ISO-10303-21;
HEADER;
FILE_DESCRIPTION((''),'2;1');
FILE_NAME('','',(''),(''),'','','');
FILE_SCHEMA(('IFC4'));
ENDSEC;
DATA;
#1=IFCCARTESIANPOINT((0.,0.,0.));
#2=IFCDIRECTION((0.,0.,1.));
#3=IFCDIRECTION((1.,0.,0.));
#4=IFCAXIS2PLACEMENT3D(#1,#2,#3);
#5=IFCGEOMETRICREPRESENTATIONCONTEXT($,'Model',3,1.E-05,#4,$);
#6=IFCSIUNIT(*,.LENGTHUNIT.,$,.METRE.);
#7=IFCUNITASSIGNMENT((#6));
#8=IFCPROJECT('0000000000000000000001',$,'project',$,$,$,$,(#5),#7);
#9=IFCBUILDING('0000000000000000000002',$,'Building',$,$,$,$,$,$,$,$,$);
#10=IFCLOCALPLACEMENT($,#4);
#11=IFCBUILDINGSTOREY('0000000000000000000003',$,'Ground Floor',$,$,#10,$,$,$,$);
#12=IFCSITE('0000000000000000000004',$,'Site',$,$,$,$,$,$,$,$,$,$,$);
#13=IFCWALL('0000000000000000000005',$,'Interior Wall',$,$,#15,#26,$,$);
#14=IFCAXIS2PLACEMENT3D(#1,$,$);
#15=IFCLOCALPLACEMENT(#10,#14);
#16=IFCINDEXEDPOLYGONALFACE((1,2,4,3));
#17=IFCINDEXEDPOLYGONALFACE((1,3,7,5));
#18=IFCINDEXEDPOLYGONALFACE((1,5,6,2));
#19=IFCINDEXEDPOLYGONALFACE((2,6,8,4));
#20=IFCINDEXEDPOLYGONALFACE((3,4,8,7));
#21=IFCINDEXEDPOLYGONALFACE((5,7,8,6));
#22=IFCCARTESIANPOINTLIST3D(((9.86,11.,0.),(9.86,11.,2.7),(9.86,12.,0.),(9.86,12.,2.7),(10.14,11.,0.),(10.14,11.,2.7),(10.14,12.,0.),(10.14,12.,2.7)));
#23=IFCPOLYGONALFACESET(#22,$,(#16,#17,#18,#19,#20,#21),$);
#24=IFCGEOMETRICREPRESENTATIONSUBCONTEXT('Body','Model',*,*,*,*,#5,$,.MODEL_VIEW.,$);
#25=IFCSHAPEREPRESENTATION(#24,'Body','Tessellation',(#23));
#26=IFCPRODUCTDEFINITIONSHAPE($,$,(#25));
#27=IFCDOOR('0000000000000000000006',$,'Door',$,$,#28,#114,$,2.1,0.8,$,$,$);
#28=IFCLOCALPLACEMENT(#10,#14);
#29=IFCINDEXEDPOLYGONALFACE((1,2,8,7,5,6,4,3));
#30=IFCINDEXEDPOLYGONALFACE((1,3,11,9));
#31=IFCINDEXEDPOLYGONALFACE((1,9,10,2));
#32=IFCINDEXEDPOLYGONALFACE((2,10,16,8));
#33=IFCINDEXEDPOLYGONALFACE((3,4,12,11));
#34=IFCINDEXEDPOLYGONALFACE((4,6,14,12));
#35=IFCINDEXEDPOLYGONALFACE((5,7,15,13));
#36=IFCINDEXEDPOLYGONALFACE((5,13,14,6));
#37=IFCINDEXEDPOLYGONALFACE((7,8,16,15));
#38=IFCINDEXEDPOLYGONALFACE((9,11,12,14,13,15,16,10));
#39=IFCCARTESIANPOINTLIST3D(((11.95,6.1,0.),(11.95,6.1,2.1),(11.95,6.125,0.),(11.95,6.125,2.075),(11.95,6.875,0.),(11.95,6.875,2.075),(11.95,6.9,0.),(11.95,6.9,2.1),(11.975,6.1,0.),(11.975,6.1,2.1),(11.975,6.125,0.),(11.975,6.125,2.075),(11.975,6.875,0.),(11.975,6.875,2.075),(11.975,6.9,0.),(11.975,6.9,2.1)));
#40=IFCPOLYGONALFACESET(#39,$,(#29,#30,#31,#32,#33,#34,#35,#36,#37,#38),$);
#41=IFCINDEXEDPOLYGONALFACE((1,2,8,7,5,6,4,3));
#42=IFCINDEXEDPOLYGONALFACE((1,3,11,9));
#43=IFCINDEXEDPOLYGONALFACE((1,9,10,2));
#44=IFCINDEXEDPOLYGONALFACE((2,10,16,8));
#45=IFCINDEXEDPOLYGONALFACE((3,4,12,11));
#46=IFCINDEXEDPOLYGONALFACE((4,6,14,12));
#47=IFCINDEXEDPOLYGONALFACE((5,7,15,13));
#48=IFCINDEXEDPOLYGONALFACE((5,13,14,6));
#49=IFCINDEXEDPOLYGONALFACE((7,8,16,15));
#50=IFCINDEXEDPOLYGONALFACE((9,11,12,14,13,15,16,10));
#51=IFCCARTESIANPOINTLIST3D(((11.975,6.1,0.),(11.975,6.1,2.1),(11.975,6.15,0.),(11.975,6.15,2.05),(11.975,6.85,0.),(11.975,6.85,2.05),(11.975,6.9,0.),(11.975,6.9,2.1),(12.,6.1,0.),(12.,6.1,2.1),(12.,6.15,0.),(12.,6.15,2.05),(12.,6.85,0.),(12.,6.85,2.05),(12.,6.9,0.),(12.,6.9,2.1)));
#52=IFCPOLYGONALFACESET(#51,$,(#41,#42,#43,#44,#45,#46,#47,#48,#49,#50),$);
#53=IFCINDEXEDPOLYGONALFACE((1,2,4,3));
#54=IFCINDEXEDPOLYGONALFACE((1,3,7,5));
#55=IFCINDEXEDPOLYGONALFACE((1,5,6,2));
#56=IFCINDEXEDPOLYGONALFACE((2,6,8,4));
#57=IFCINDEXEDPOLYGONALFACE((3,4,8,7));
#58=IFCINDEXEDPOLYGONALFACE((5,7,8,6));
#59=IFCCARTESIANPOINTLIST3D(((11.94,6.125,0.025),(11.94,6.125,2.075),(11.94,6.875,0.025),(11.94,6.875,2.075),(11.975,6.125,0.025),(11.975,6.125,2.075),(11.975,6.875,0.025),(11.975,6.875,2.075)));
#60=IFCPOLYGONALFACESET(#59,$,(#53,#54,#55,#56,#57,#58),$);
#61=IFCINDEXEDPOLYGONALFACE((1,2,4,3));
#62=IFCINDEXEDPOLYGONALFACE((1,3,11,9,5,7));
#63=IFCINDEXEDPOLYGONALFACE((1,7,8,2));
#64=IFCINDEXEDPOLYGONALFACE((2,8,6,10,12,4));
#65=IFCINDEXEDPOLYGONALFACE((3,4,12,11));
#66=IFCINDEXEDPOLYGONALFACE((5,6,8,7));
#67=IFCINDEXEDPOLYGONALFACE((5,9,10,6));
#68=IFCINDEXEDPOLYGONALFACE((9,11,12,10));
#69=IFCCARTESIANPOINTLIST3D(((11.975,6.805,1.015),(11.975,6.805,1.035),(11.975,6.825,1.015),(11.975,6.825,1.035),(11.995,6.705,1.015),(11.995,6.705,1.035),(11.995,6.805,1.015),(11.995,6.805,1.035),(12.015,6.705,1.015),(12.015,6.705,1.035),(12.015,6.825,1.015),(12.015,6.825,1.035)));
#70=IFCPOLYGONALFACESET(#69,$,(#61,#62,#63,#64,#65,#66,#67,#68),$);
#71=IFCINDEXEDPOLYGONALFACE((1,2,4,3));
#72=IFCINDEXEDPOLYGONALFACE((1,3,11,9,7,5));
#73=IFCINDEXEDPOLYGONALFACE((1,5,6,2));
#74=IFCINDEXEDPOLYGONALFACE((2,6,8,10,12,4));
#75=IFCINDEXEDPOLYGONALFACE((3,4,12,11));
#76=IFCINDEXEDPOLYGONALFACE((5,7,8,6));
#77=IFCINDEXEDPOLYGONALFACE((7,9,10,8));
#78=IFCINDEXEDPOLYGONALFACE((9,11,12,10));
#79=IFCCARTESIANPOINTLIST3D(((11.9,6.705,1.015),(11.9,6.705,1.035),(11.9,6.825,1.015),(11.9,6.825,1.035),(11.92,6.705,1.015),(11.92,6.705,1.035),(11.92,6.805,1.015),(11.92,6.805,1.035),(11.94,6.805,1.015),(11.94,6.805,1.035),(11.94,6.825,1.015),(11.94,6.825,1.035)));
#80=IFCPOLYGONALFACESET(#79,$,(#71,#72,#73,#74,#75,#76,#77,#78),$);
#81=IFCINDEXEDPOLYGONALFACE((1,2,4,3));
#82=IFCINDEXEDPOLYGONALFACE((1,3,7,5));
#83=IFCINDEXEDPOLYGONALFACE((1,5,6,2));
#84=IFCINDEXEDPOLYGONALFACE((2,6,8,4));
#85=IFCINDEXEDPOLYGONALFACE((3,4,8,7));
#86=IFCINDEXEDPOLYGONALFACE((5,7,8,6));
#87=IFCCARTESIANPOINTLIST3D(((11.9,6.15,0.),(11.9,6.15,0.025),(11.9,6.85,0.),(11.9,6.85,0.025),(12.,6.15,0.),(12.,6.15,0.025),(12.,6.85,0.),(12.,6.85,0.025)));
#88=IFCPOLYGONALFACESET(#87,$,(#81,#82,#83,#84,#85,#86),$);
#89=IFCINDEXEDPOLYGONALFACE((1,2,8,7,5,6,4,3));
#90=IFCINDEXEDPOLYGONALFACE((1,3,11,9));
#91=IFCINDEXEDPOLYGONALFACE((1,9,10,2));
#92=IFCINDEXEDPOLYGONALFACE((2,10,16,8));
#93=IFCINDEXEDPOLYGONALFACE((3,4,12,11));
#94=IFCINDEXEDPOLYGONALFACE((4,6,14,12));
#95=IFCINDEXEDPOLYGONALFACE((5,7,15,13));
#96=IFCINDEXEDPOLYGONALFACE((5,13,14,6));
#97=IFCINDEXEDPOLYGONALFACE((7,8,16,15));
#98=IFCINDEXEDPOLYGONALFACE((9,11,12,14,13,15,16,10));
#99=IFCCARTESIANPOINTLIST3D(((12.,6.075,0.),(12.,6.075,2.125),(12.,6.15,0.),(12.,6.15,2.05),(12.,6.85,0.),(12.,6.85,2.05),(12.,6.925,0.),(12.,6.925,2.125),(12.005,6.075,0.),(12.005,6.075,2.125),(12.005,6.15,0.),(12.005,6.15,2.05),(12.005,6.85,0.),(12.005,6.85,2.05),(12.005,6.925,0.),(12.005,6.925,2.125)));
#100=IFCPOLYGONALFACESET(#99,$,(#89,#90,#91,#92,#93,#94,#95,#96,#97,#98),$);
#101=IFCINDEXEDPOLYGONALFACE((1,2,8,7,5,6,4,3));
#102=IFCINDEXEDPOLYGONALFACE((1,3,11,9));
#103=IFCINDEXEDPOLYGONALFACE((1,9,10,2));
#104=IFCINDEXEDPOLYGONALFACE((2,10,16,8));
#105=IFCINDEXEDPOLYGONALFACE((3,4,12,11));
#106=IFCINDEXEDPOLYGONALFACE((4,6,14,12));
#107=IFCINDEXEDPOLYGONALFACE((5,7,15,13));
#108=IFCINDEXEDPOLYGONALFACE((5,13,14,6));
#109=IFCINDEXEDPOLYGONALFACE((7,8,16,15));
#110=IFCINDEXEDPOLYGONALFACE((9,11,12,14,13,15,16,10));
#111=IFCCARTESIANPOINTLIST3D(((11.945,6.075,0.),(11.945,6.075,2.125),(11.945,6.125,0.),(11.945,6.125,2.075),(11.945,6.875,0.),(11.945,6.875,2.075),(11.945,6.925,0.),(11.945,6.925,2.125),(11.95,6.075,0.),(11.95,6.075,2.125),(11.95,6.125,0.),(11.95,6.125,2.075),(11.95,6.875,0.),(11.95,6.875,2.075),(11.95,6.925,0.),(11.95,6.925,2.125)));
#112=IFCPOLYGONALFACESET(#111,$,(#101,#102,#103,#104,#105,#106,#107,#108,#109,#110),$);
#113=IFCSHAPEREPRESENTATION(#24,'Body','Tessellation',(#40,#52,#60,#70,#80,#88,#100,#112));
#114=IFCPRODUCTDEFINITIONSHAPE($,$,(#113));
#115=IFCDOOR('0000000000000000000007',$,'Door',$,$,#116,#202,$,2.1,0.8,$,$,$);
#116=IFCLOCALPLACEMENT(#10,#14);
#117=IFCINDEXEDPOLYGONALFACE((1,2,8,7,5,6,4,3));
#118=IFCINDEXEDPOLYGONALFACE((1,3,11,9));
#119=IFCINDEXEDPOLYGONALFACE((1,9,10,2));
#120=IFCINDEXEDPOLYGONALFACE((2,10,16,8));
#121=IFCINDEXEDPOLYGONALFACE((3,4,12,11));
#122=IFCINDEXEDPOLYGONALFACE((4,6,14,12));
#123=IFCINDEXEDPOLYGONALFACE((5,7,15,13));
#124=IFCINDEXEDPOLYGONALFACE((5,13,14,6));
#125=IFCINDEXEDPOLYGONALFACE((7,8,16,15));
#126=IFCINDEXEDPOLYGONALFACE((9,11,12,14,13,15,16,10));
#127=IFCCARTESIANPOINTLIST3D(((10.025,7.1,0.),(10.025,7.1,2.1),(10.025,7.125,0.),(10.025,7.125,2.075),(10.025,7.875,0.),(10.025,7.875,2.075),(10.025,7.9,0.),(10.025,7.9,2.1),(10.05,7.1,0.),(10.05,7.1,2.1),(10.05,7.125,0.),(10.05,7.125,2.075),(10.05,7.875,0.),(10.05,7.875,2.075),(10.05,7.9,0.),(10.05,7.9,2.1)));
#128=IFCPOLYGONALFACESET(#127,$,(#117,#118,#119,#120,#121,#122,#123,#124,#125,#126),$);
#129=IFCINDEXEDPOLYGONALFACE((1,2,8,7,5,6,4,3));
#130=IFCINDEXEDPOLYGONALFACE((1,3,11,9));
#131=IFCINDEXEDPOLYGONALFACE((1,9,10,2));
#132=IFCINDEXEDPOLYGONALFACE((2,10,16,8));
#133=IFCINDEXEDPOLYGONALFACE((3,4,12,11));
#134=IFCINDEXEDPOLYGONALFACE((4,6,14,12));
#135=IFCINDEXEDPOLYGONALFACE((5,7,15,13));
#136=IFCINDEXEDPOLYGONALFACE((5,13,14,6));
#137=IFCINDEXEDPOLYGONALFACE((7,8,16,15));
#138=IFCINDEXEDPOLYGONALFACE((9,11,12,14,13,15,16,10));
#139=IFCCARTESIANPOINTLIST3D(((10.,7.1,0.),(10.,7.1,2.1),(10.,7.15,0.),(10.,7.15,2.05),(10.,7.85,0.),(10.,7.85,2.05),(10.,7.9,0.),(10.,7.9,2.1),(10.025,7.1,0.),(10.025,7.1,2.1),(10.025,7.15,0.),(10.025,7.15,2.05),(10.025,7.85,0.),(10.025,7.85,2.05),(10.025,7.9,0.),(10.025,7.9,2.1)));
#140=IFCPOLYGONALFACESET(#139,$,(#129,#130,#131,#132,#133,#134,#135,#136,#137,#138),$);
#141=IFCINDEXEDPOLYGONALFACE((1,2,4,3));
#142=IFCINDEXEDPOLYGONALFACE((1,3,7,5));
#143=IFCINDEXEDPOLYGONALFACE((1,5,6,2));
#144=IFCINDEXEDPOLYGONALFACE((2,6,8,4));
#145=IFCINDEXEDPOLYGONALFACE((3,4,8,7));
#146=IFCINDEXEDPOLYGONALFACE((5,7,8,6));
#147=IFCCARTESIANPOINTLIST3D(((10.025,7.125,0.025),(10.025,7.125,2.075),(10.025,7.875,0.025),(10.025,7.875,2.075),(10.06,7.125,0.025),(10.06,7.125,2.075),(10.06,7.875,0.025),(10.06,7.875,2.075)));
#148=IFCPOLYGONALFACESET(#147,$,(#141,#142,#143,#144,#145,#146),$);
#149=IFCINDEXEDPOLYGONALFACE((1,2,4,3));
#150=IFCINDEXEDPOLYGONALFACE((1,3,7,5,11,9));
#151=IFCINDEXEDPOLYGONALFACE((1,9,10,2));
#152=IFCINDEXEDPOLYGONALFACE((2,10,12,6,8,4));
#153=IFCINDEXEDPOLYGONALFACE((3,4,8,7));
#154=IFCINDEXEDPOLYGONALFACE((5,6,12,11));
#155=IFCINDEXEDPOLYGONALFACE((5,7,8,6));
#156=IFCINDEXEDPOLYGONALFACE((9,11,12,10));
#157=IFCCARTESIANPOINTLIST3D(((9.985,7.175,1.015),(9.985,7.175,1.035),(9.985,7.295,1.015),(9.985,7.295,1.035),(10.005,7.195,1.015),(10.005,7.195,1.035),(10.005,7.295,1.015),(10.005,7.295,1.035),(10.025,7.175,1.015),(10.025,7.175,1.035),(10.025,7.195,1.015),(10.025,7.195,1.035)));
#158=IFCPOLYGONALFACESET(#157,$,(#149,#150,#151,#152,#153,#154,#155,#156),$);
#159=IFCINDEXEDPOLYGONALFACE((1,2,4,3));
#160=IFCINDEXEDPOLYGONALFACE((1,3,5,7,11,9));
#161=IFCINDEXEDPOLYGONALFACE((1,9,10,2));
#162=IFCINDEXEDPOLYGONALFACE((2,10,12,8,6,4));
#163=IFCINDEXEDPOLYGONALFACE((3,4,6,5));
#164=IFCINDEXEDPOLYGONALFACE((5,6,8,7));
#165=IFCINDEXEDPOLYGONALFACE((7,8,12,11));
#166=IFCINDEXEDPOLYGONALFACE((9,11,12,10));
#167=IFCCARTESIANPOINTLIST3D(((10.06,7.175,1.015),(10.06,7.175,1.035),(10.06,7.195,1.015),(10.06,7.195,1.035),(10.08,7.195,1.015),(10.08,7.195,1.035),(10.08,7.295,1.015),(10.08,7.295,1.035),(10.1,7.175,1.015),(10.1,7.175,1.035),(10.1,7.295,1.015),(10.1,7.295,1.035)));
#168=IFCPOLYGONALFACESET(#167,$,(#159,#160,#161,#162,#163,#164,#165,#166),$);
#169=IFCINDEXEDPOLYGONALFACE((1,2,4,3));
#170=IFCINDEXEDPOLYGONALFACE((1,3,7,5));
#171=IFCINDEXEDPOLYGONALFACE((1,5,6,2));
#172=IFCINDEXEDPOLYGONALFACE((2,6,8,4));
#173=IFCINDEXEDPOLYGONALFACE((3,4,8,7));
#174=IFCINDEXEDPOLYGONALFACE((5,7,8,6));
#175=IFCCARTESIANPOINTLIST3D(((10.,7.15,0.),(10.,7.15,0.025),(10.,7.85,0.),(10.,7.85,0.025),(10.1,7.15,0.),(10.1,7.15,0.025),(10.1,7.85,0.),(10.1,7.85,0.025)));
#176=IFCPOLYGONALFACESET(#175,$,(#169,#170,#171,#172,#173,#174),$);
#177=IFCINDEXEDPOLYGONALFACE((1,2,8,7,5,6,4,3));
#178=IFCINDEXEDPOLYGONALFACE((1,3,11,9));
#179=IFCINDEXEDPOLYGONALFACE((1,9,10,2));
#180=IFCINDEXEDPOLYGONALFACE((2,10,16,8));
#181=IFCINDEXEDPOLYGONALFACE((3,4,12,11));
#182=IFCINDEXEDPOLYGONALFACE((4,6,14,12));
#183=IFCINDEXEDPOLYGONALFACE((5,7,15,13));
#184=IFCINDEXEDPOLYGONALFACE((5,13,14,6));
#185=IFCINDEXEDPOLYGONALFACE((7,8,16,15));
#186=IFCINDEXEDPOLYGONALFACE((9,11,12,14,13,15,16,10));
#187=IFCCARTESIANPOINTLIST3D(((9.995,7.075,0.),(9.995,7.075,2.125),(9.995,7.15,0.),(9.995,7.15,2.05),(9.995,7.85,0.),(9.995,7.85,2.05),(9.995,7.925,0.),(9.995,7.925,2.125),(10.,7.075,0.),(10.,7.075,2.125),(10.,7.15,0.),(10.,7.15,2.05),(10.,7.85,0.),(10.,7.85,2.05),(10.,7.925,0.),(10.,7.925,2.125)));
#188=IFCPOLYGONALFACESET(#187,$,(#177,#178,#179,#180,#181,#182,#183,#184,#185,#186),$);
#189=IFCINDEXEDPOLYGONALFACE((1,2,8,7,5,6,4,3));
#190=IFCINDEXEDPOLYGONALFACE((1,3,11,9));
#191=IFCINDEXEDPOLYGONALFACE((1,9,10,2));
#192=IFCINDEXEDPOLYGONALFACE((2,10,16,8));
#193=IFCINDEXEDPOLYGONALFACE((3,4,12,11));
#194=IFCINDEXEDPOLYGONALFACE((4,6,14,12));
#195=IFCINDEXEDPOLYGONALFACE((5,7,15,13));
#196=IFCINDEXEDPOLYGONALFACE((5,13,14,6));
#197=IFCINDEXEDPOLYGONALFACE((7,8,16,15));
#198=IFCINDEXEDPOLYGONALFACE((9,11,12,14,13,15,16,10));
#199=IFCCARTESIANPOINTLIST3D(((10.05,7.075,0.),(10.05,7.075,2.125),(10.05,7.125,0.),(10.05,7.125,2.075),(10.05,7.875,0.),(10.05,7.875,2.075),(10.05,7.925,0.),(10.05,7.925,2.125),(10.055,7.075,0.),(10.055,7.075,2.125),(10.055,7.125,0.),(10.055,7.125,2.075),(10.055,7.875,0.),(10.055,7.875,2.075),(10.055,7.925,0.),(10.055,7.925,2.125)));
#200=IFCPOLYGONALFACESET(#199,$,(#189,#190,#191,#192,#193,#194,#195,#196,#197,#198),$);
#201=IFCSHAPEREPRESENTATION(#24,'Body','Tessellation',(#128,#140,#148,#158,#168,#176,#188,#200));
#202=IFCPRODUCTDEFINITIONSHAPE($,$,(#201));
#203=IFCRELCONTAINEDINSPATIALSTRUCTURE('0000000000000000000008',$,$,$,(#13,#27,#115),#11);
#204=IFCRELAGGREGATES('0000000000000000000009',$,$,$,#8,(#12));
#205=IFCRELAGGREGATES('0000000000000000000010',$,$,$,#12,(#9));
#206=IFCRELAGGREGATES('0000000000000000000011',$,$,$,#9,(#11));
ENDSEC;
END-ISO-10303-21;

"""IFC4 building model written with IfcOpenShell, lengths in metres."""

from ifc_helpers import new_model, si_unit, frame, origin_with_axes, place, context, subcontext, project, spatial, line, indexed_curve, outline, extrude, element, save


model = new_model("IFC4")

# Units and contexts
model_context = context("Model", 3, precision=1e-05, world=origin_with_axes())
body_context = subcontext(model_context, "Body", "Model", "MODEL_VIEW")
ifc_project = project(units=[si_unit("LENGTHUNIT", "METRE")], contexts=[model_context])

# Site, building, storey
site = spatial("IfcSite", under=ifc_project, Name="Site")
building = spatial("IfcBuilding", under=site, Name="Building")
storey_placement = place(None, origin_with_axes())
storey = spatial("IfcBuildingStorey", under=building, at=storey_placement, Name="Ground Floor")

# Wall
wall_1_placement = place(storey_placement, frame((10.0, 12.0, 0.0), z_axis=(0.0, 0.0, 1.0), x_axis=(0.0, -1.0, 0.0)))
element("IfcWall", 1, at=wall_1_placement, inside=storey, Name="Interior Wall", context=body_context, shape_type="SweptSolid", body=[
    extrude(outline(indexed_curve([(0.0, 0.0), (0.0, 0.28), (1.0, 0.28), (1.0, 0.0), (0.0, 0.0)], self_intersect=False)), frame((0.0, -0.14, 0.0), z_axis=(0.0, 0.0, 1.0), x_axis=(1.0, 0.0, 0.0)), (0.0, 0.0, 1.0), 2.7),
])

# Doors
door_1_placement = place(storey_placement, frame((12.0, 6.1, 0.0), z_axis=(0.0, 0.0, 1.0), x_axis=(0.0, 1.0, 0.0)))
element("IfcDoor", 2, at=door_1_placement, inside=storey, Name="Door", OverallHeight=2.1, OverallWidth=0.8, context=body_context, shape_type="SweptSolid", body=[
    extrude(outline(indexed_curve([(0.0, 0.0), (0.0, 2.1), (0.8, 2.1), (0.8, 0.0), (0.775, 0.0), (0.775, 2.075), (0.025, 2.075), (0.025, 0.0)], segments=[line(1, 2, 3, 4, 5, 6, 7, 8, 1)])), frame((0.0, 0.025, 0.0), z_axis=(0.0, -1.0, 0.0), x_axis=(1.0, 0.0, 0.0)), (0.0, 0.0, -1.0), 0.025),
    extrude(outline(indexed_curve([(0.0, 0.0), (0.0, 2.1), (0.8, 2.1), (0.8, 0.0), (0.75, 0.0), (0.75, 2.05), (0.05, 2.05), (0.05, 0.0)], segments=[line(1, 2, 3, 4, 5, 6, 7, 8, 1)])), frame((0.0, 0.0, 0.0), z_axis=(0.0, -1.0, 0.0), x_axis=(1.0, 0.0, 0.0)), (0.0, 0.0, -1.0), 0.025),
    extrude(outline(indexed_curve([(0.0, 0.0), (0.75, 0.0), (0.75, 0.035), (0.0, 0.035)], segments=[line(1, 2, 3, 4, 1)])), frame((0.025, 0.025, 0.025), z_axis=(0.0, 0.0, 1.0), x_axis=(1.0, 0.0, 0.0)), (0.0, 0.0, 1.0), 2.05),
    extrude(outline(indexed_curve([(0.0, 0.0), (0.0, -0.04), (-0.12, -0.04), (-0.12, -0.02), (-0.02, -0.02), (-0.02, 0.0)], segments=[line(1, 2, 3, 4, 5, 6, 1)])), frame((0.725, 0.025, 1.015), z_axis=(0.0, 0.0, 1.0), x_axis=(1.0, 0.0, 0.0)), (0.0, 0.0, 1.0), 0.02),
    extrude(outline(indexed_curve([(0.0, 0.0), (0.0, 0.04), (-0.12, 0.04), (-0.12, 0.02), (-0.02, 0.02), (-0.02, 0.0)], segments=[line(1, 2, 3, 4, 5, 6, 1)])), frame((0.725, 0.06, 1.015), z_axis=(0.0, 0.0, 1.0), x_axis=(1.0, 0.0, 0.0)), (0.0, 0.0, 1.0), 0.02),
    extrude(outline(indexed_curve([(0.0, 0.0), (0.7, 0.0), (0.7, 0.1), (0.0, 0.1)], segments=[line(1, 2, 3, 4, 1)])), frame((0.05, 0.0, 0.0), z_axis=(0.0, 0.0, 1.0), x_axis=(1.0, 0.0, 0.0)), (0.0, 0.0, 1.0), 0.025),
    extrude(outline(indexed_curve([(0.0, 0.0), (0.0, 2.125), (0.85, 2.125), (0.85, 0.0), (0.775, 0.0), (0.775, 2.05), (0.075, 2.05), (0.075, 0.0)], segments=[line(1, 2, 3, 4, 5, 6, 7, 8, 1)])), frame((-0.025, -0.005, 0.0), z_axis=(0.0, -1.0, 0.0), x_axis=(1.0, 0.0, 0.0)), (0.0, 0.0, -1.0), 0.005),
    extrude(outline(indexed_curve([(0.0, 0.0), (0.0, 2.125), (0.85, 2.125), (0.85, 0.0), (0.8, 0.0), (0.8, 2.075), (0.05, 2.075), (0.05, 0.0)], segments=[line(1, 2, 3, 4, 5, 6, 7, 8, 1)])), frame((-0.025, 0.05, 0.0), z_axis=(0.0, -1.0, 0.0), x_axis=(1.0, 0.0, 0.0)), (0.0, 0.0, -1.0), 0.005),
])
door_2_placement = place(storey_placement, frame((10.0, 7.9, 0.0), z_axis=(0.0, 0.0, 1.0), x_axis=(0.0, -1.0, 0.0)))
element("IfcDoor", 3, at=door_2_placement, inside=storey, Name="Door", OverallHeight=2.1, OverallWidth=0.8, context=body_context, shape_type="SweptSolid", body=[
    extrude(outline(indexed_curve([(0.0, 0.0), (0.0, 2.1), (0.8, 2.1), (0.8, 0.0), (0.775, 0.0), (0.775, 2.075), (0.025, 2.075), (0.025, 0.0)], segments=[line(1, 2, 3, 4, 5, 6, 7, 8, 1)])), frame((0.0, 0.025, 0.0), z_axis=(0.0, -1.0, 0.0), x_axis=(1.0, 0.0, 0.0)), (0.0, 0.0, -1.0), 0.025),
    extrude(outline(indexed_curve([(0.0, 0.0), (0.0, 2.1), (0.8, 2.1), (0.8, 0.0), (0.75, 0.0), (0.75, 2.05), (0.05, 2.05), (0.05, 0.0)], segments=[line(1, 2, 3, 4, 5, 6, 7, 8, 1)])), frame((0.0, 0.0, 0.0), z_axis=(0.0, -1.0, 0.0), x_axis=(1.0, 0.0, 0.0)), (0.0, 0.0, -1.0), 0.025),
    extrude(outline(indexed_curve([(0.0, 0.0), (0.75, 0.0), (0.75, 0.035), (0.0, 0.035)], segments=[line(1, 2, 3, 4, 1)])), frame((0.025, 0.025, 0.025), z_axis=(0.0, 0.0, 1.0), x_axis=(1.0, 0.0, 0.0)), (0.0, 0.0, 1.0), 2.05),
    extrude(outline(indexed_curve([(0.0, 0.0), (0.0, -0.04), (-0.12, -0.04), (-0.12, -0.02), (-0.02, -0.02), (-0.02, 0.0)], segments=[line(1, 2, 3, 4, 5, 6, 1)])), frame((0.725, 0.025, 1.015), z_axis=(0.0, 0.0, 1.0), x_axis=(1.0, 0.0, 0.0)), (0.0, 0.0, 1.0), 0.02),
    extrude(outline(indexed_curve([(0.0, 0.0), (0.0, 0.04), (-0.12, 0.04), (-0.12, 0.02), (-0.02, 0.02), (-0.02, 0.0)], segments=[line(1, 2, 3, 4, 5, 6, 1)])), frame((0.725, 0.06, 1.015), z_axis=(0.0, 0.0, 1.0), x_axis=(1.0, 0.0, 0.0)), (0.0, 0.0, 1.0), 0.02),
    extrude(outline(indexed_curve([(0.0, 0.0), (0.7, 0.0), (0.7, 0.1), (0.0, 0.1)], segments=[line(1, 2, 3, 4, 1)])), frame((0.05, 0.0, 0.0), z_axis=(0.0, 0.0, 1.0), x_axis=(1.0, 0.0, 0.0)), (0.0, 0.0, 1.0), 0.025),
    extrude(outline(indexed_curve([(0.0, 0.0), (0.0, 2.125), (0.85, 2.125), (0.85, 0.0), (0.775, 0.0), (0.775, 2.05), (0.075, 2.05), (0.075, 0.0)], segments=[line(1, 2, 3, 4, 5, 6, 7, 8, 1)])), frame((-0.025, -0.005, 0.0), z_axis=(0.0, -1.0, 0.0), x_axis=(1.0, 0.0, 0.0)), (0.0, 0.0, -1.0), 0.005),
    extrude(outline(indexed_curve([(0.0, 0.0), (0.0, 2.125), (0.85, 2.125), (0.85, 0.0), (0.8, 0.0), (0.8, 2.075), (0.05, 2.075), (0.05, 0.0)], segments=[line(1, 2, 3, 4, 5, 6, 7, 8, 1)])), frame((-0.025, 0.05, 0.0), z_axis=(0.0, -1.0, 0.0), x_axis=(1.0, 0.0, 0.0)), (0.0, 0.0, -1.0), 0.005),
])

save(model, "model.ifc")
